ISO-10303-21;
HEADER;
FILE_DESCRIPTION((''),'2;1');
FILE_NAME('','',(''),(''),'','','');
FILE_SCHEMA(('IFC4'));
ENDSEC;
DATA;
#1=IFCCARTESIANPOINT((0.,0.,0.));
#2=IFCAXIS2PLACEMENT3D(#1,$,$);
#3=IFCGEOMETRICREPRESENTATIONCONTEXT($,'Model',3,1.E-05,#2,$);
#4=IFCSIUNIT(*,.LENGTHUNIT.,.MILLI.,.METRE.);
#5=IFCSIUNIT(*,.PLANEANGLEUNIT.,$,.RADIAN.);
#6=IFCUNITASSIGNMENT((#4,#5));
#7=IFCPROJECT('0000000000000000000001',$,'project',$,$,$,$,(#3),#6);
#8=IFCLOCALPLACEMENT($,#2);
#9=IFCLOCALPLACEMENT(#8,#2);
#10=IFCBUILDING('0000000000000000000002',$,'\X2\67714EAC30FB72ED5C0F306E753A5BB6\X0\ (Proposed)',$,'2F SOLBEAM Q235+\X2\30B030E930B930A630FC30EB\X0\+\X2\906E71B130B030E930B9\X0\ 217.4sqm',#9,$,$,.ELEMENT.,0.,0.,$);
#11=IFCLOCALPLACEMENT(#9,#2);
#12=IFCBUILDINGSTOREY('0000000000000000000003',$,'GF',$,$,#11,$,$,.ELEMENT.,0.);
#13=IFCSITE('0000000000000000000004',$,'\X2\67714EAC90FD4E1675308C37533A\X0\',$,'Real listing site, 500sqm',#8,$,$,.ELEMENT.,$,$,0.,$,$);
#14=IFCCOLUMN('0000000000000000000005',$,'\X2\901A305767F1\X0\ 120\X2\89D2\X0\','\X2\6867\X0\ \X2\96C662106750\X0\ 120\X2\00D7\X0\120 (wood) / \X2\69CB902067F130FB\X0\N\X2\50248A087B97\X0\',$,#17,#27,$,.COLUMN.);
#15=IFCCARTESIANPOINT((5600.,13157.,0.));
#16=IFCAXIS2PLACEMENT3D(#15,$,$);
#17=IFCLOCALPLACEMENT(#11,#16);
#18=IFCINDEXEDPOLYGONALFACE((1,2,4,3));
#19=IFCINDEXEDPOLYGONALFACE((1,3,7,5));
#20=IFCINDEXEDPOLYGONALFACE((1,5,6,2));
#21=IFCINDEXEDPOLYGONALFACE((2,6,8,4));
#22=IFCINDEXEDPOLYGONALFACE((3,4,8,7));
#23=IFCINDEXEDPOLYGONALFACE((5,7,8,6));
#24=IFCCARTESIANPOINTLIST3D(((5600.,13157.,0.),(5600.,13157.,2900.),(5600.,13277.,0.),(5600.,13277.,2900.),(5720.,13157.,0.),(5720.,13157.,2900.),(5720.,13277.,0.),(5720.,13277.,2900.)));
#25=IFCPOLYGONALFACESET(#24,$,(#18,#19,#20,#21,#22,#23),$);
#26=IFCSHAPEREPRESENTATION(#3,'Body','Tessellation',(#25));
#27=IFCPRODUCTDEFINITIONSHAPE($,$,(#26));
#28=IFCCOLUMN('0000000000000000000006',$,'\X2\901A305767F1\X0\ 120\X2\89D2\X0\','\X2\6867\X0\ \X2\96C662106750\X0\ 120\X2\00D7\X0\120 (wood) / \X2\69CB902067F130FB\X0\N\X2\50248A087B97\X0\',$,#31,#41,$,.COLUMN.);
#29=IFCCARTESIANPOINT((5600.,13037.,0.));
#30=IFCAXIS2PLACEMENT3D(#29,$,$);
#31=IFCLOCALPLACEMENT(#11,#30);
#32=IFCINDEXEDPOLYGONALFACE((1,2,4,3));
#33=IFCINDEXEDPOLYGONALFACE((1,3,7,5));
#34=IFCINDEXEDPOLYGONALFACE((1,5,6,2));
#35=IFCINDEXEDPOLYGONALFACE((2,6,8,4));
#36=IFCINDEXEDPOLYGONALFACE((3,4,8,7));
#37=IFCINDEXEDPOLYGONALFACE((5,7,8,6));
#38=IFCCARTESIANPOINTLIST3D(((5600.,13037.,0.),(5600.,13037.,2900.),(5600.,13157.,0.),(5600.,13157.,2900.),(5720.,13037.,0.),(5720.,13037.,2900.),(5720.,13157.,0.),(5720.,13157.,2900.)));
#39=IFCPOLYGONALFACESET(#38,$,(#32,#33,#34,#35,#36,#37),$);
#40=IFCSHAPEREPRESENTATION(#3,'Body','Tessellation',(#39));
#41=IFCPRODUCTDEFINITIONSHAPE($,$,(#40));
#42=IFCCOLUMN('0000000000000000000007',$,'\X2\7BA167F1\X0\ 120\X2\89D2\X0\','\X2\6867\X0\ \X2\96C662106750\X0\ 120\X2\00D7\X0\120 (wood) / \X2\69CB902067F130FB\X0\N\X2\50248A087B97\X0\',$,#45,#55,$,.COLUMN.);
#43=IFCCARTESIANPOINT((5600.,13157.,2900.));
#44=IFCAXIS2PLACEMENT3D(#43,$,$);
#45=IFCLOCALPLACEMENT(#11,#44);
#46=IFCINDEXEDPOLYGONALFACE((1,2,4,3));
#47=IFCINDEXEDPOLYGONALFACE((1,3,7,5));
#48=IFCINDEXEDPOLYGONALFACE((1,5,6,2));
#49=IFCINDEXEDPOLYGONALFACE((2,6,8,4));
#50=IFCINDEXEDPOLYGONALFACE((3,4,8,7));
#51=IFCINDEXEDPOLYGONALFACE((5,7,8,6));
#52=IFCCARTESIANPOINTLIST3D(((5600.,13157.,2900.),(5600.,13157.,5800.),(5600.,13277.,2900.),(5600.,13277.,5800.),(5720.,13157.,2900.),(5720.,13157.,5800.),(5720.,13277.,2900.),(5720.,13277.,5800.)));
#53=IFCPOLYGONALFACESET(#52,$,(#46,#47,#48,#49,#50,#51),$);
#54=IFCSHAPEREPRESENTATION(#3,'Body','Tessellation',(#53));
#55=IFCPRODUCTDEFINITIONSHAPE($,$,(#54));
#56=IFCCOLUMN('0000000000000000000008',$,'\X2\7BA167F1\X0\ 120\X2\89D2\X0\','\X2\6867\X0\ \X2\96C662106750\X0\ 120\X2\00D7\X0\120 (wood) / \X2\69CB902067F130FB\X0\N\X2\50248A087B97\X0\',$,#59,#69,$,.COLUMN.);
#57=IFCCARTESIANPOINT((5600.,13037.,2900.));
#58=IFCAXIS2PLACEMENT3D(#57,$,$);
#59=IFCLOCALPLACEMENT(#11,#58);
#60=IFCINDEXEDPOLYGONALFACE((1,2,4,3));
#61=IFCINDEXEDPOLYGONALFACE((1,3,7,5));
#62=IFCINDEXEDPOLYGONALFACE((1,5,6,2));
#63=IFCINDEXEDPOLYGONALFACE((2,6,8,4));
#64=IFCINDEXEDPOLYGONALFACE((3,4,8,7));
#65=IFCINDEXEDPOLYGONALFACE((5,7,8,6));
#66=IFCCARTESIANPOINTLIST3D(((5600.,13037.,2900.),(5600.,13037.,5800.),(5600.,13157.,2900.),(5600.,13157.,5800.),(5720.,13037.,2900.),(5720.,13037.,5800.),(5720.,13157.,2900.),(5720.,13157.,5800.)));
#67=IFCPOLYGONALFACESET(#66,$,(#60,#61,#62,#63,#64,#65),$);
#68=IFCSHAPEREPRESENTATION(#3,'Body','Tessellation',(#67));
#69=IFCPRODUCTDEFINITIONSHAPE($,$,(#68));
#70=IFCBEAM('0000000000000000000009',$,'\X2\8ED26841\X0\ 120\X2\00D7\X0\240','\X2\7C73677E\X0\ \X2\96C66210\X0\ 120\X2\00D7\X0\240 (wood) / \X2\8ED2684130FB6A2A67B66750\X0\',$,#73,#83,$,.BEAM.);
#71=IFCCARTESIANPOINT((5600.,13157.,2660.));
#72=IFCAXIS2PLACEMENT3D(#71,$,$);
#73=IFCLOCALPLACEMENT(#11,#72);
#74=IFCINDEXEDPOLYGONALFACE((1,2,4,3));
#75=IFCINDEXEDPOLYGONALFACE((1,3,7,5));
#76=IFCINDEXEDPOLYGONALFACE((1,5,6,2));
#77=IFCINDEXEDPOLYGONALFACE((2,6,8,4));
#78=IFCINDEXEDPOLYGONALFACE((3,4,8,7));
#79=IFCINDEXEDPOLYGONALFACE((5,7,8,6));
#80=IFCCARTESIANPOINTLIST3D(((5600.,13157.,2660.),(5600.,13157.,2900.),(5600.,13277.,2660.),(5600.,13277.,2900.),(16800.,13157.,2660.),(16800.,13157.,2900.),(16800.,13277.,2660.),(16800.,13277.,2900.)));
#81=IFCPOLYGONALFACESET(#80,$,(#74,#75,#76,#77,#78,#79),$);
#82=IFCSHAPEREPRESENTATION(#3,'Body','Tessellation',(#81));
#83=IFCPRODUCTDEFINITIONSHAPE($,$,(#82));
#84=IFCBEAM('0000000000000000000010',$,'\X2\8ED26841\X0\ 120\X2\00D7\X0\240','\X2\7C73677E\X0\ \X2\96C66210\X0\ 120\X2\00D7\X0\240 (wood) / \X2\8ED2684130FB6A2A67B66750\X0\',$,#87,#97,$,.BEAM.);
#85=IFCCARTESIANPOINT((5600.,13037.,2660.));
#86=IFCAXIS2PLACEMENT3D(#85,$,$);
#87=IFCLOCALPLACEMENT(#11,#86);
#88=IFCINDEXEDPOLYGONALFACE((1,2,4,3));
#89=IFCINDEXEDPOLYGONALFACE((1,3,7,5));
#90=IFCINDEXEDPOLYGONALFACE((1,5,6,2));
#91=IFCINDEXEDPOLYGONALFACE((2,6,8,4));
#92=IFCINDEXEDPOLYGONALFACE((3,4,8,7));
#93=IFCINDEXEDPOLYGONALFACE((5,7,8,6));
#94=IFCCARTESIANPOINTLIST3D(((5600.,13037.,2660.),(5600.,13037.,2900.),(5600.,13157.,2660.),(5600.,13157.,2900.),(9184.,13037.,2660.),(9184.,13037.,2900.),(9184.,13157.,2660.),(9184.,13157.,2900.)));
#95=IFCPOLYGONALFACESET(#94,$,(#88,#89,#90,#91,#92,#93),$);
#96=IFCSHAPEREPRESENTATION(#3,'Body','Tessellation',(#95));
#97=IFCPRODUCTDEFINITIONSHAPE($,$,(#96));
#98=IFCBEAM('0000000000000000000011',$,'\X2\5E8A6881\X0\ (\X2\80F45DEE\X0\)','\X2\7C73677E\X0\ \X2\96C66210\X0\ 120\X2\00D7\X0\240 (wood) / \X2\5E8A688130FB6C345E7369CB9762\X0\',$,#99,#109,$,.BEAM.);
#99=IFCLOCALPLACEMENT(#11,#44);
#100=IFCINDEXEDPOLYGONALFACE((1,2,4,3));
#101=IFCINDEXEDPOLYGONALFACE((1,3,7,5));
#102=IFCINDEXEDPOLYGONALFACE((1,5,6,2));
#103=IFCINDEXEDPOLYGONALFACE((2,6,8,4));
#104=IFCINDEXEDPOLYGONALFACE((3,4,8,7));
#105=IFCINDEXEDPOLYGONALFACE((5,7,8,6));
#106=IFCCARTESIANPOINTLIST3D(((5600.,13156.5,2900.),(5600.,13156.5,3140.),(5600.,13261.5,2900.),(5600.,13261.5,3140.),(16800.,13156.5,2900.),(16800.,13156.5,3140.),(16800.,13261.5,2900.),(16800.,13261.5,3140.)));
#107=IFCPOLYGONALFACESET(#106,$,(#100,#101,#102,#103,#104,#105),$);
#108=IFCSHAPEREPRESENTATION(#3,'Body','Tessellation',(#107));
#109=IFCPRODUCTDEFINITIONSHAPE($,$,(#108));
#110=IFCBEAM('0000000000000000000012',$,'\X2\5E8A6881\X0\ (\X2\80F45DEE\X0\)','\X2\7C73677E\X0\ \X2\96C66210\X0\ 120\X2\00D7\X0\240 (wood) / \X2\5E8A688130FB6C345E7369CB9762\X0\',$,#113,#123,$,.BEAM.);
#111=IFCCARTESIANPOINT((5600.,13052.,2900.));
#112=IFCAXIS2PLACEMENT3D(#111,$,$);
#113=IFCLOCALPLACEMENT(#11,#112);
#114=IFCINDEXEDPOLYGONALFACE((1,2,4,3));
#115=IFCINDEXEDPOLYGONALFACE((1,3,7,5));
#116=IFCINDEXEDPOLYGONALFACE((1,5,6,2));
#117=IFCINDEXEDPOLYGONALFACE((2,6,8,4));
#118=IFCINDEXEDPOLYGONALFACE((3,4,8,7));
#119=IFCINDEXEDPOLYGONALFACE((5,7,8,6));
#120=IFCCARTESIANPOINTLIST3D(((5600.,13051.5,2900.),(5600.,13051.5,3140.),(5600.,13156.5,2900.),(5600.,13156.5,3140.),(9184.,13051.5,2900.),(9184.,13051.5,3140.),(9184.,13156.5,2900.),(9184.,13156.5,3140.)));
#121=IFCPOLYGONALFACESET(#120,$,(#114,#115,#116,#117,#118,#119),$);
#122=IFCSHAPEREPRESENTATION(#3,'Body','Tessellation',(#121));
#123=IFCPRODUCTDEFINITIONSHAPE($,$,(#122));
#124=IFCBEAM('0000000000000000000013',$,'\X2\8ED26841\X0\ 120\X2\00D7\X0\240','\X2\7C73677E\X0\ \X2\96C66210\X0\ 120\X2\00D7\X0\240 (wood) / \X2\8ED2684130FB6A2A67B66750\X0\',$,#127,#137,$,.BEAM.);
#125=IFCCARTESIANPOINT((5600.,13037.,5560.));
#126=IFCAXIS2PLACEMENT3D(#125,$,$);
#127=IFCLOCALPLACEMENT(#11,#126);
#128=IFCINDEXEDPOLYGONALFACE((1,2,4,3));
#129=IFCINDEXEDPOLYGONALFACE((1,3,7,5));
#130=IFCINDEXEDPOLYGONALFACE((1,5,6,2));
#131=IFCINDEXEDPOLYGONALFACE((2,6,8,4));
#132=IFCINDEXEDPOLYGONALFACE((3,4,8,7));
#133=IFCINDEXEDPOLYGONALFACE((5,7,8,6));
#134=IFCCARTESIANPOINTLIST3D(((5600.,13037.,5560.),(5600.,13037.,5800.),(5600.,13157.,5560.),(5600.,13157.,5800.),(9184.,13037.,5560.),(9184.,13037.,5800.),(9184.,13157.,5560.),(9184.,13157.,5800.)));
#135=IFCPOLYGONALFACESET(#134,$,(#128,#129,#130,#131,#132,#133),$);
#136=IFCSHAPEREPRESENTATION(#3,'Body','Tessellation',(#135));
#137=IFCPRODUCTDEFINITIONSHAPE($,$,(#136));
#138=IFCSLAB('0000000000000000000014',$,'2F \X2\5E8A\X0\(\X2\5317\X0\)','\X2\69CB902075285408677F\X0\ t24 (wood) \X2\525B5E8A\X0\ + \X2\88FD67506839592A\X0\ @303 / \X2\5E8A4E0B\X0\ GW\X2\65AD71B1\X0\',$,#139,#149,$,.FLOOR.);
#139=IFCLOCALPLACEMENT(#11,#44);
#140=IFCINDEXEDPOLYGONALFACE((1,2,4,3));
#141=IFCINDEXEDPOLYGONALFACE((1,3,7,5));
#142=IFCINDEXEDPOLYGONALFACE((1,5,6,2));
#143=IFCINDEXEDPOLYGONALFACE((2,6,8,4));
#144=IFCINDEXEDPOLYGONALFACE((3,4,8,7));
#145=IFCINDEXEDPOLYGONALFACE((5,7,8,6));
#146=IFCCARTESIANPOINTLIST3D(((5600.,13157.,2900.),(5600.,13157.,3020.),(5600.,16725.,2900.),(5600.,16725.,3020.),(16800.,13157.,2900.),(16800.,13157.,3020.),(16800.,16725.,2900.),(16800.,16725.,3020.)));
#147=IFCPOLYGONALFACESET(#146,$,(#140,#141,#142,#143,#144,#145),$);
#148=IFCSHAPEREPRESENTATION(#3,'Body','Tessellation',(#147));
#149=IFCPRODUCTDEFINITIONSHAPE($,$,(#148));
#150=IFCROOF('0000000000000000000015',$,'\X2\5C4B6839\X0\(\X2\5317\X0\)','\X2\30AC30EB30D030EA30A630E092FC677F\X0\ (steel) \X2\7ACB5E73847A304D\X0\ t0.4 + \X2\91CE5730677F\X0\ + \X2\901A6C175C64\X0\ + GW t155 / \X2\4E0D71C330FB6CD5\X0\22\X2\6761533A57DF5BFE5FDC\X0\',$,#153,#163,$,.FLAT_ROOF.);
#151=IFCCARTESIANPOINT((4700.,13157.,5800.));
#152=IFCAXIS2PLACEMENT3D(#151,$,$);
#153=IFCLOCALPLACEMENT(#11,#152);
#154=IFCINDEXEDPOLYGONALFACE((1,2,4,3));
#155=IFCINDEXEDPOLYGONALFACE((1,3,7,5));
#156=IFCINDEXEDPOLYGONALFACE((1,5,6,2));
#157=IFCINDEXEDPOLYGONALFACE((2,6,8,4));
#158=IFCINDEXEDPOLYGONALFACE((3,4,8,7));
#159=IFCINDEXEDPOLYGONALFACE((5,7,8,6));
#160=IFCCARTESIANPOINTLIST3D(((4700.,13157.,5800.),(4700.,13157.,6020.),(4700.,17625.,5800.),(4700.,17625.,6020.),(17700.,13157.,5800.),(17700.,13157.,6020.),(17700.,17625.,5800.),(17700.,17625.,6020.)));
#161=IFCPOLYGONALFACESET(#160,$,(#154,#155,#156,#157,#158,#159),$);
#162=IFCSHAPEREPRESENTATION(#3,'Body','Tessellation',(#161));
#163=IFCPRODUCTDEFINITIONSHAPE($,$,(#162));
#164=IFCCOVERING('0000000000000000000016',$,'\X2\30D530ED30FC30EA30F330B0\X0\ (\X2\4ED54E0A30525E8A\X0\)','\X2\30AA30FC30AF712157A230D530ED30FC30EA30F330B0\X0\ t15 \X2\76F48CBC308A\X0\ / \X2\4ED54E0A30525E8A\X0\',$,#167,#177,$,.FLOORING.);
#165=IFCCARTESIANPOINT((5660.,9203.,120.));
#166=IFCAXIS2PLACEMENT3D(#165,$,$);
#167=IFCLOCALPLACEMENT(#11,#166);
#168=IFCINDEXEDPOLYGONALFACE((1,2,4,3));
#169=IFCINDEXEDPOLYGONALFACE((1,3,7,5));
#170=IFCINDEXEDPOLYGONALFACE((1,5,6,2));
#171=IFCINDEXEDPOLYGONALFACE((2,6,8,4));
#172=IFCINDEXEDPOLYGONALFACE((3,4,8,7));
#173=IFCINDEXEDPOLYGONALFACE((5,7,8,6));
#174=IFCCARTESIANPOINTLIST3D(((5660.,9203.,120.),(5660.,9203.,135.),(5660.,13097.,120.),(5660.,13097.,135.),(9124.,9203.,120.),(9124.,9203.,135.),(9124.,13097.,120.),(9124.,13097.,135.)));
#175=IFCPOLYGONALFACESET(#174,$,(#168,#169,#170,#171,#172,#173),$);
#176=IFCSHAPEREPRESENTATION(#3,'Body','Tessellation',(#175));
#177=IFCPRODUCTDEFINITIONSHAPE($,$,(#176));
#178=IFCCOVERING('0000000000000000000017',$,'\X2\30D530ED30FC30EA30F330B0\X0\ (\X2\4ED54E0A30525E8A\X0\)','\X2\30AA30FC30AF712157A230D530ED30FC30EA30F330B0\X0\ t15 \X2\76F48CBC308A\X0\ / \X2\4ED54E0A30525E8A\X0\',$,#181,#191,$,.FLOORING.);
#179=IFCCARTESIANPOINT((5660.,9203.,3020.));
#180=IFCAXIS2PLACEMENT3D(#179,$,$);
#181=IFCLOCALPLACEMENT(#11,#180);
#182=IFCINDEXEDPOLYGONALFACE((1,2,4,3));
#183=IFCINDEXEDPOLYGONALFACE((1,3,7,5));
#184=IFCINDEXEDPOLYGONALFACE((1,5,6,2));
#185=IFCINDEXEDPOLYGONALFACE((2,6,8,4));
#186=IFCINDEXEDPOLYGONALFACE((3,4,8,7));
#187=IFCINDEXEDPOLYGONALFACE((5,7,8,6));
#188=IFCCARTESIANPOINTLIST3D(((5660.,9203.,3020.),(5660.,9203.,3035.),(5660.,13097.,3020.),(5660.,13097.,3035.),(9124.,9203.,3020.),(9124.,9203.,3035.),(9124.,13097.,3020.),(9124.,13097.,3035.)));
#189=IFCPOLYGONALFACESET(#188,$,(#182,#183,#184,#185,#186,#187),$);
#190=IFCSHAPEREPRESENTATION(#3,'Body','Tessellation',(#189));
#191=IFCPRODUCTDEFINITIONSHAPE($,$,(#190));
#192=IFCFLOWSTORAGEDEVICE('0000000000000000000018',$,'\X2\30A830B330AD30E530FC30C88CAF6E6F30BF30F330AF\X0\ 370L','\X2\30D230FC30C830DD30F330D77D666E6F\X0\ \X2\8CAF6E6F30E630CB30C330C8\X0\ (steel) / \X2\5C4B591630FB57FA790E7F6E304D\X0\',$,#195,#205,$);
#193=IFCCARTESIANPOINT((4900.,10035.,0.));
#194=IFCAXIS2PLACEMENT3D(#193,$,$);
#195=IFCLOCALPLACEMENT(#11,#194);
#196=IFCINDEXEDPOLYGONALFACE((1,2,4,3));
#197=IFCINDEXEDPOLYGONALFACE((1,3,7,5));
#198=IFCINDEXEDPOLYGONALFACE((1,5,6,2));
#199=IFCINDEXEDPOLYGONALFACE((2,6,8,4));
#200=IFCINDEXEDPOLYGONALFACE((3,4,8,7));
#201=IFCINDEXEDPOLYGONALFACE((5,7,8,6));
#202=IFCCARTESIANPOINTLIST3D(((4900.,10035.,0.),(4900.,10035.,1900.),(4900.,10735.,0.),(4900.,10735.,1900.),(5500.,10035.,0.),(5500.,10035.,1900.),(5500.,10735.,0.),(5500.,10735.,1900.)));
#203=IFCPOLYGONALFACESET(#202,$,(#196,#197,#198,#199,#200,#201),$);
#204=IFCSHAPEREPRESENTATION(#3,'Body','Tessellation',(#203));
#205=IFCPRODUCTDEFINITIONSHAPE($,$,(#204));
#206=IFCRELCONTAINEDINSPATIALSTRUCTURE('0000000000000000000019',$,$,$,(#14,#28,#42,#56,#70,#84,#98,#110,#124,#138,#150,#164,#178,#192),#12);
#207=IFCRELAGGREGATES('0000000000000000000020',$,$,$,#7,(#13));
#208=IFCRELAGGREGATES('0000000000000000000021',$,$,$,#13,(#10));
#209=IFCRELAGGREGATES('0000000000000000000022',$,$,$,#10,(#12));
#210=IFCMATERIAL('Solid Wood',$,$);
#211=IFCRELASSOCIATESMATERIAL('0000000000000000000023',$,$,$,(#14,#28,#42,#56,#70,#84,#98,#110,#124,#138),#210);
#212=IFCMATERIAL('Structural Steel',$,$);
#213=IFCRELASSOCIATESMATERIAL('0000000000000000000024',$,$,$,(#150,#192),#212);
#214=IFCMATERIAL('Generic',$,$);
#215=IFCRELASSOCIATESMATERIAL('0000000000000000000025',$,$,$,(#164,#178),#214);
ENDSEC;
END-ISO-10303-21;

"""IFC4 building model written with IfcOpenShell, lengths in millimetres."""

from ifc_helpers import new_model, si_unit, frame, frame_2d, origin, place, context, project, spatial, rectangle, extrude, material, element, save


model = new_model("IFC4")

# Units and contexts
model_context = context("Model", 3, precision=1e-05, world=origin())
ifc_project = project(units=[si_unit("LENGTHUNIT", "METRE", prefix="MILLI"), si_unit("PLANEANGLEUNIT", "RADIAN")], contexts=[model_context])

# Site, building, storey
site_placement = place(None, origin())
site = spatial("IfcSite", under=ifc_project, at=site_placement, Name="東京都世田谷区", ObjectType="Real listing site, 500sqm", CompositionType="ELEMENT", RefElevation=0.0)
building_placement = place(site_placement, origin())
building = spatial("IfcBuilding", under=site, at=building_placement, Name="東京・狭小の町家 (Proposed)", ObjectType="2F SOLBEAM Q235+グラスウール+遮熱グラス 217.4sqm", CompositionType="ELEMENT", ElevationOfRefHeight=0.0, ElevationOfTerrain=0.0)
storey_placement = place(building_placement, origin())
storey = spatial("IfcBuildingStorey", under=building, at=storey_placement, Name="GF", CompositionType="ELEMENT", Elevation=0.0)

# Columns
ifc_material_1 = material(Name="Solid Wood")
column_1_placement = place(storey_placement, frame((5600.0, 13157.0, 0.0)))
element("IfcColumn", 1, at=column_1_placement, inside=storey, material=ifc_material_1, Name="通し柱 120角", Description="桧 集成材 120×120 (wood) / 構造柱・N値計算", PredefinedType="COLUMN", context=model_context, shape_type="SweptSolid", body=[
    extrude(rectangle(XDim=120.0, YDim=120.0, at=frame_2d((60.0, 60.0))), frame((5600.0, 13157.0, 0.0)), (0.0, 0.0, 1.0), 2900.0),
])
column_2_placement = place(storey_placement, frame((5600.0, 13037.0, 0.0)))
element("IfcColumn", 2, at=column_2_placement, inside=storey, material=ifc_material_1, Name="通し柱 120角", Description="桧 集成材 120×120 (wood) / 構造柱・N値計算", PredefinedType="COLUMN", context=model_context, shape_type="SweptSolid", body=[
    extrude(rectangle(XDim=120.0, YDim=120.0, at=frame_2d((60.0, 60.0))), frame((5600.0, 13037.0, 0.0)), (0.0, 0.0, 1.0), 2900.0),
])
column_3_placement = place(storey_placement, frame((5600.0, 13157.0, 2900.0)))
element("IfcColumn", 3, at=column_3_placement, inside=storey, material=ifc_material_1, Name="管柱 120角", Description="桧 集成材 120×120 (wood) / 構造柱・N値計算", PredefinedType="COLUMN", context=model_context, shape_type="SweptSolid", body=[
    extrude(rectangle(XDim=120.0, YDim=120.0, at=frame_2d((60.0, 60.0))), frame((5600.0, 13157.0, 2900.0)), (0.0, 0.0, 1.0), 2900.0),
])
column_4_placement = place(storey_placement, frame((5600.0, 13037.0, 2900.0)))
element("IfcColumn", 4, at=column_4_placement, inside=storey, material=ifc_material_1, Name="管柱 120角", Description="桧 集成材 120×120 (wood) / 構造柱・N値計算", PredefinedType="COLUMN", context=model_context, shape_type="SweptSolid", body=[
    extrude(rectangle(XDim=120.0, YDim=120.0, at=frame_2d((60.0, 60.0))), frame((5600.0, 13037.0, 2900.0)), (0.0, 0.0, 1.0), 2900.0),
])

# Beams
beam_1_placement = place(storey_placement, frame((5600.0, 13157.0, 2660.0)))
element("IfcBeam", 5, at=beam_1_placement, inside=storey, material=ifc_material_1, Name="軒桁 120×240", Description="米松 集成 120×240 (wood) / 軒桁・横架材", PredefinedType="BEAM", context=model_context, shape_type="SweptSolid", body=[
    extrude(rectangle(XDim=11200.0, YDim=120.0, at=frame_2d((5600.0, 60.0))), frame((5600.0, 13157.0, 2660.0)), (0.0, 0.0, 1.0), 240.0),
])
beam_2_placement = place(storey_placement, frame((5600.0, 13037.0, 2660.0)))
element("IfcBeam", 6, at=beam_2_placement, inside=storey, material=ifc_material_1, Name="軒桁 120×240", Description="米松 集成 120×240 (wood) / 軒桁・横架材", PredefinedType="BEAM", context=model_context, shape_type="SweptSolid", body=[
    extrude(rectangle(XDim=3584.0, YDim=120.0, at=frame_2d((1792.0, 60.0))), frame((5600.0, 13037.0, 2660.0)), (0.0, 0.0, 1.0), 240.0),
])
beam_3_placement = place(storey_placement, frame((5600.0, 13157.0, 2900.0)))
element("IfcBeam", 7, at=beam_3_placement, inside=storey, material=ifc_material_1, Name="床梁 (胴差)", Description="米松 集成 120×240 (wood) / 床梁・水平構面", PredefinedType="BEAM", context=model_context, shape_type="SweptSolid", body=[
    extrude(rectangle(XDim=11200.0, YDim=105.0, at=frame_2d((5600.0, 52.0))), frame((5600.0, 13157.0, 2900.0)), (0.0, 0.0, 1.0), 240.0),
])
beam_4_placement = place(storey_placement, frame((5600.0, 13052.0, 2900.0)))
element("IfcBeam", 8, at=beam_4_placement, inside=storey, material=ifc_material_1, Name="床梁 (胴差)", Description="米松 集成 120×240 (wood) / 床梁・水平構面", PredefinedType="BEAM", context=model_context, shape_type="SweptSolid", body=[
    extrude(rectangle(XDim=3584.0, YDim=105.0, at=frame_2d((1792.0, 52.0))), frame((5600.0, 13052.0, 2900.0)), (0.0, 0.0, 1.0), 240.0),
])
beam_5_placement = place(storey_placement, frame((5600.0, 13037.0, 5560.0)))
element("IfcBeam", 9, at=beam_5_placement, inside=storey, material=ifc_material_1, Name="軒桁 120×240", Description="米松 集成 120×240 (wood) / 軒桁・横架材", PredefinedType="BEAM", context=model_context, shape_type="SweptSolid", body=[
    extrude(rectangle(XDim=3584.0, YDim=120.0, at=frame_2d((1792.0, 60.0))), frame((5600.0, 13037.0, 5560.0)), (0.0, 0.0, 1.0), 240.0),
])

# Slab
slab_1_placement = place(storey_placement, frame((5600.0, 13157.0, 2900.0)))
element("IfcSlab", 10, at=slab_1_placement, inside=storey, material=ifc_material_1, Name="2F 床(北)", Description="構造用合板 t24 (wood) 剛床 + 製材根太 @303 / 床下 GW断熱", PredefinedType="FLOOR", context=model_context, shape_type="SweptSolid", body=[
    extrude(rectangle(XDim=11200.0, YDim=3568.0, at=frame_2d((5600.0, 1784.0))), frame((5600.0, 13157.0, 2900.0)), (0.0, 0.0, 1.0), 120.0),
])

# Roof
ifc_material_2 = material(Name="Structural Steel")
for number, where, name in (
    (11, (4700.0, 13157.0, 5800.0), "屋根(北)"),
):
    element("IfcRoof", number, at=place(storey_placement, frame(where)), inside=storey, material=ifc_material_2, Name=name, Description="ガルバリウム鋼板 (steel) 立平葺き t0.4 + 野地板 + 通気層 + GW t155 / 不燃・法22条区域対応", PredefinedType="FLAT_ROOF", context=model_context, shape_type="SweptSolid", body=[
        extrude(rectangle(XDim=13000.0, YDim=4468.0, at=frame_2d((6500.0, 2234.0))), frame((4700.0, 13157.0, 5800.0)), (0.0, 0.0, 1.0), 220.0),
    ])

# Coverings
ifc_material_3 = material(Name="Generic")
covering_1_placement = place(storey_placement, frame((5660.0, 9203.0, 120.0)))
element("IfcCovering", 12, at=covering_1_placement, inside=storey, material=ifc_material_3, Name="フローリング (仕上げ床)", Description="オーク無垢フローリング t15 直貼り / 仕上げ床", PredefinedType="FLOORING", context=model_context, shape_type="SweptSolid", body=[
    extrude(rectangle(XDim=3464.0, YDim=3894.0, at=frame_2d((1732.0, 1947.0))), frame((5660.0, 9203.0, 120.0)), (0.0, 0.0, 1.0), 15.0),
])
covering_2_placement = place(storey_placement, frame((5660.0, 9203.0, 3020.0)))
element("IfcCovering", 13, at=covering_2_placement, inside=storey, material=ifc_material_3, Name="フローリング (仕上げ床)", Description="オーク無垢フローリング t15 直貼り / 仕上げ床", PredefinedType="FLOORING", context=model_context, shape_type="SweptSolid", body=[
    extrude(rectangle(XDim=3464.0, YDim=3894.0, at=frame_2d((1732.0, 1947.0))), frame((5660.0, 9203.0, 3020.0)), (0.0, 0.0, 1.0), 15.0),
])

# Flow storage device
flow_storage_device_placement = place(storey_placement, frame((4900.0, 10035.0, 0.0)))
element("IfcFlowStorageDevice", 14, at=flow_storage_device_placement, inside=storey, material=ifc_material_2, Name="エコキュート貯湯タンク 370L", Description="ヒートポンプ給湯 貯湯ユニット (steel) / 屋外・基礎置き", context=model_context, shape_type="SweptSolid", body=[
    extrude(rectangle(XDim=600.0, YDim=700.0, at=frame_2d((300.0, 350.0))), frame((4900.0, 10035.0, 0.0)), (0.0, 0.0, 1.0), 1900.0),
])

save(model, "model.ifc")
